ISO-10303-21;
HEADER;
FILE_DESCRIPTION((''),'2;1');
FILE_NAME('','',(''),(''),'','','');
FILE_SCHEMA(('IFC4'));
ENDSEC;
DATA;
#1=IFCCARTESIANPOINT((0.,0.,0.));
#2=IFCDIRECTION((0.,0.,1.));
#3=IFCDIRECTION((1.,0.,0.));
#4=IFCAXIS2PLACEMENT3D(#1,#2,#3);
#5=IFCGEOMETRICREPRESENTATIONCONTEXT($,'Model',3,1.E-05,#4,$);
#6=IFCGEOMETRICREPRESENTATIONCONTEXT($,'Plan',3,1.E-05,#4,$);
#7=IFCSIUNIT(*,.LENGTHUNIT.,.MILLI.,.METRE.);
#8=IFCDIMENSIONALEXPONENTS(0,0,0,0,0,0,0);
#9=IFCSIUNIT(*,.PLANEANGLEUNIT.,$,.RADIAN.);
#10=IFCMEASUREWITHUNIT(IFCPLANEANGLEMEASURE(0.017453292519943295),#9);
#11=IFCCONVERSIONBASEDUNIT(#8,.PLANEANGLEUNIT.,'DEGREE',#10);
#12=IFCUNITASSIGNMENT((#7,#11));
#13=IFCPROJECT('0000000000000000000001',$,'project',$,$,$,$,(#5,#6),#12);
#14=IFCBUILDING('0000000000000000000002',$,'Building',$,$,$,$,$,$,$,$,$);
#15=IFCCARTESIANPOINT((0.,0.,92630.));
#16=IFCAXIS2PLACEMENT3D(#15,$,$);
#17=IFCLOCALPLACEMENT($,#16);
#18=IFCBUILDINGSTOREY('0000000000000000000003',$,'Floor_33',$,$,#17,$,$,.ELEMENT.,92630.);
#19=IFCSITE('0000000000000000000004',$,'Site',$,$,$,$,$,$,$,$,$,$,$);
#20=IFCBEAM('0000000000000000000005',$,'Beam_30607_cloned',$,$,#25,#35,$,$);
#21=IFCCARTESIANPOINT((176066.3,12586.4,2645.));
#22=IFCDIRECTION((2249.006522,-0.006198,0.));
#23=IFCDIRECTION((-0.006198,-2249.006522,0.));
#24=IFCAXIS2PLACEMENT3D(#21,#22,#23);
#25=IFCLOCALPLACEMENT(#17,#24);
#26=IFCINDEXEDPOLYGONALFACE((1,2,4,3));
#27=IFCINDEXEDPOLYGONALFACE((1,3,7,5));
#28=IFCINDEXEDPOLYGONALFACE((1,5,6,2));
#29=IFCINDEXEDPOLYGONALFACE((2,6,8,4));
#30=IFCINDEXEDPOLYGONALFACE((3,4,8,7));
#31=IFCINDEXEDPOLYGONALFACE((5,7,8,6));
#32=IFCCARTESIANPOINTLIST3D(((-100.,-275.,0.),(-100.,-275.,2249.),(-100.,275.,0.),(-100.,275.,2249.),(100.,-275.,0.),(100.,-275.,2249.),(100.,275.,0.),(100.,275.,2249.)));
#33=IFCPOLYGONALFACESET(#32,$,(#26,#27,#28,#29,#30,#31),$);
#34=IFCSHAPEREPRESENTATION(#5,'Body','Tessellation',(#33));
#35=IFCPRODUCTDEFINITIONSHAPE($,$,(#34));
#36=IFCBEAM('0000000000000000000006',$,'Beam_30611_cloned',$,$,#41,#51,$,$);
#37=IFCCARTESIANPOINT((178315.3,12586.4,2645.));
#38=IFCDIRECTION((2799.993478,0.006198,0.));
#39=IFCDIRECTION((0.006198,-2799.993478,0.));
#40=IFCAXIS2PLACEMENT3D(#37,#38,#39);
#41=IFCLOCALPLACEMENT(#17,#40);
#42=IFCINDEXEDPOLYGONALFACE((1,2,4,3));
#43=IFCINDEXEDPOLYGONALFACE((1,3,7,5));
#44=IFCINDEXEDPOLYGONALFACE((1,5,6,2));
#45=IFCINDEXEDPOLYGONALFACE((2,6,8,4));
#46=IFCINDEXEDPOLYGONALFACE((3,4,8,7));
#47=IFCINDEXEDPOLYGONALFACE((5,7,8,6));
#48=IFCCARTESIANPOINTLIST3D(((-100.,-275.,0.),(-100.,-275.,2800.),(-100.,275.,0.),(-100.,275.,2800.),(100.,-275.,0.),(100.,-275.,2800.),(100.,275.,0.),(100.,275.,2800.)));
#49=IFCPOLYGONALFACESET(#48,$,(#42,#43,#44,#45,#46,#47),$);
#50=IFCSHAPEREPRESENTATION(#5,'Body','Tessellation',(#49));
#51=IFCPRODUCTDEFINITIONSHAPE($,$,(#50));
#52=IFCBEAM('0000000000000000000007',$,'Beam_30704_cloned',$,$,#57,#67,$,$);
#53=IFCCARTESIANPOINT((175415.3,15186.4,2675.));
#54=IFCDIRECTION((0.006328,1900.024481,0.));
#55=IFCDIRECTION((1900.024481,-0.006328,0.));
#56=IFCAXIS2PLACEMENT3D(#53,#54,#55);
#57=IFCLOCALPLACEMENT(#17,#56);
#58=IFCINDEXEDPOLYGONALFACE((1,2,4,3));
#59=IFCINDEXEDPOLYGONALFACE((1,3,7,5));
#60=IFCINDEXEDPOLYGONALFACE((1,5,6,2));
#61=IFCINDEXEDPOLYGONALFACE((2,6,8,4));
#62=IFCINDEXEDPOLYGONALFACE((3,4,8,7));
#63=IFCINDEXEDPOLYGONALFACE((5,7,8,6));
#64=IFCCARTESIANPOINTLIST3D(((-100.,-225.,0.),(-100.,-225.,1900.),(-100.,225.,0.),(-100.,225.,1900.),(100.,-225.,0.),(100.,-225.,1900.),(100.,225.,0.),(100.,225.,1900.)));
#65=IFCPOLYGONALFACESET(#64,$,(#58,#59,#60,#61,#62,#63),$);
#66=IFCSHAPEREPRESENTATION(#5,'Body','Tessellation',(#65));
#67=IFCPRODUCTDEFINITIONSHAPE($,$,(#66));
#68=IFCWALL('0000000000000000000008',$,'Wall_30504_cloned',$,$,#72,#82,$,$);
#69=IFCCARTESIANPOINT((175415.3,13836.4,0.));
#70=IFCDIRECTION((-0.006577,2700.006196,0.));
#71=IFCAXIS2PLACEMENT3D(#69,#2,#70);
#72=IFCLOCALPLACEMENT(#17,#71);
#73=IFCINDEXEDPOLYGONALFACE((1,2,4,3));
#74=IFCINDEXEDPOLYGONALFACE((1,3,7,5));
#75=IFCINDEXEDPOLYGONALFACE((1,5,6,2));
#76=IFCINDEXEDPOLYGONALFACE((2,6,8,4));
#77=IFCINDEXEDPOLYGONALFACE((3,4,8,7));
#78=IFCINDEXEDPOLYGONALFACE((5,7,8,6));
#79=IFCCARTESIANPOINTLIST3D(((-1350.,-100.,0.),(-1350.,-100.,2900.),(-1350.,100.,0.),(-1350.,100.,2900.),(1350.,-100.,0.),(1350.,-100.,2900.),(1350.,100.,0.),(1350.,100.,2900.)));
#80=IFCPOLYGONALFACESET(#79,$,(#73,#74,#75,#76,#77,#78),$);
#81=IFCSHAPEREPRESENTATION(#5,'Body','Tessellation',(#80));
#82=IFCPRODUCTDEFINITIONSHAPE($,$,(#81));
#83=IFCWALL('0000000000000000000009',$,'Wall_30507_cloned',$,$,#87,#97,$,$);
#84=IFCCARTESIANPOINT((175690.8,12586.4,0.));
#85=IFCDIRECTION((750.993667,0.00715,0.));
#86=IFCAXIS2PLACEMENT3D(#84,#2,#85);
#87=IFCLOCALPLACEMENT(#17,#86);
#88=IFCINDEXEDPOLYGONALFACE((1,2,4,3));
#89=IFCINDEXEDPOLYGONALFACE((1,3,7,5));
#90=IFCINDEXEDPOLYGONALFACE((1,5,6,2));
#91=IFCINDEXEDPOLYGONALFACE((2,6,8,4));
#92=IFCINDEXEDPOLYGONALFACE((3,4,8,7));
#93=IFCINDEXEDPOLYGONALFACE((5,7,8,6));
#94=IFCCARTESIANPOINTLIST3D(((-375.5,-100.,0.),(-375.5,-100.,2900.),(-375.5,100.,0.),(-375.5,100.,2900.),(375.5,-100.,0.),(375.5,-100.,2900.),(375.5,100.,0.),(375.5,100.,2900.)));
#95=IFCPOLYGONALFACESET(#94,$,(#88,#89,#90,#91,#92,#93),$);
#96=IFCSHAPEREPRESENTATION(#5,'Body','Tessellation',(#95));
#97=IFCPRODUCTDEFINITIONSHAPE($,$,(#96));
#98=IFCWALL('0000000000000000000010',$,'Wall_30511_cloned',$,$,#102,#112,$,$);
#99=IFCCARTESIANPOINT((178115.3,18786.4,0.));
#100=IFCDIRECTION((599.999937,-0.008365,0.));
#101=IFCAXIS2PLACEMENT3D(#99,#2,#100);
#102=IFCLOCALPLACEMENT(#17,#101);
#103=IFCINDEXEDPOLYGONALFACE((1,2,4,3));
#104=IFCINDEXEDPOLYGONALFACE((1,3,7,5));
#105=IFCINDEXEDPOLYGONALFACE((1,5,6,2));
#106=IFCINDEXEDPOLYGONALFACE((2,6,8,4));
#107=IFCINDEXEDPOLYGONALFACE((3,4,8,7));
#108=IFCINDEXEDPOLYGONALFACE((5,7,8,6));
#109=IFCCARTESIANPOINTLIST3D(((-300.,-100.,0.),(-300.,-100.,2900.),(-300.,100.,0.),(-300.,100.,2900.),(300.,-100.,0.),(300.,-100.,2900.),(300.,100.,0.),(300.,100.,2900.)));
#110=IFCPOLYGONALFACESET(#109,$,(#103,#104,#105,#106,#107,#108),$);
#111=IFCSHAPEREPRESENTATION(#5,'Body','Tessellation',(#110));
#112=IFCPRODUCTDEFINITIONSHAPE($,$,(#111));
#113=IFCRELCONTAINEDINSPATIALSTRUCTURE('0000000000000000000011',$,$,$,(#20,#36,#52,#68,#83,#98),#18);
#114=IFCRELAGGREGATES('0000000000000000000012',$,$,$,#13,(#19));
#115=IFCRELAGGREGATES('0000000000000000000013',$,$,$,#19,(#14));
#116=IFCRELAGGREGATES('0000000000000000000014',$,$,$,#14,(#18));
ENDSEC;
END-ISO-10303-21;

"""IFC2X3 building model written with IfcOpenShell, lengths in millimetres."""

from ifc_helpers import new_model, entity, si_unit, converted_unit, frame, origin_with_axes, origin_2d, place, context, project, spatial, rectangle, extrude, source, transform, mapped, element, save


model = new_model("IFC2X3")

# Units and contexts
model_context = context("Model", 3, precision=1e-05, world=origin_with_axes())
plan_context = context("Plan", 3, precision=1e-05, world=origin_with_axes())
ifc_project = project(units=[si_unit("LENGTHUNIT", "METRE", prefix="MILLI"), converted_unit("PLANEANGLEUNIT", "DEGREE", entity("IfcPlaneAngleMeasure", 0.017453292519943295), si_unit("PLANEANGLEUNIT", "RADIAN"), dimensions=[0, 0, 0, 0, 0, 0, 0])], contexts=[model_context, plan_context])

# Site, building, storey
site = spatial("IfcSite", under=ifc_project, Name="Site")
building = spatial("IfcBuilding", under=site, Name="Building")
storey_placement = place(None, frame((0.0, 0.0, 92630.0)))
storey = spatial("IfcBuildingStorey", under=building, at=storey_placement, Name="Floor_33", CompositionType="ELEMENT", Elevation=92630.0)

# Beams
shared_shape_1 = source(origin_with_axes(), model_context, "Body", "SweptSolid", [
    extrude(rectangle(XDim=200.0, YDim=550.0, at=origin_2d()), origin_with_axes(), (0.0, 0.0, 1.0), 2249.0),
])
beam_1_placement = place(storey_placement, frame((176066.3, 12586.4, 2645.0), z_axis=(2249.006522, -0.006198, 0.0), x_axis=(-0.006198, -2249.006522, 0.0)))
element("IfcBeam", 1, at=beam_1_placement, inside=storey, Name="Beam_30607_cloned", context=model_context, shape_type="MappedRepresentation", body=[
    mapped(shared_shape_1, transform((0.0, 0.0, 0.0), x_axis=(1.0, 0.0, 0.0), y_axis=(0.0, 1.0, 0.0), z_axis=(0.0, 0.0, 1.0), scale=1.0)),
])
shared_shape_2 = source(origin_with_axes(), model_context, "Body", "SweptSolid", [
    extrude(rectangle(XDim=200.0, YDim=550.0, at=origin_2d()), origin_with_axes(), (0.0, 0.0, 1.0), 2800.0),
])
beam_2_placement = place(storey_placement, frame((178315.3, 12586.4, 2645.0), z_axis=(2799.993478, 0.006198, 0.0), x_axis=(0.006198, -2799.993478, 0.0)))
element("IfcBeam", 2, at=beam_2_placement, inside=storey, Name="Beam_30611_cloned", context=model_context, shape_type="MappedRepresentation", body=[
    mapped(shared_shape_2, transform((0.0, 0.0, 0.0), x_axis=(1.0, 0.0, 0.0), y_axis=(0.0, 1.0, 0.0), z_axis=(0.0, 0.0, 1.0), scale=1.0)),
])
shared_shape_3 = source(origin_with_axes(), model_context, "Body", "SweptSolid", [
    extrude(rectangle(XDim=200.0, YDim=450.0, at=origin_2d()), origin_with_axes(), (0.0, 0.0, 1.0), 1900.0),
])
beam_3_placement = place(storey_placement, frame((175415.3, 15186.4, 2675.0), z_axis=(0.006328, 1900.024481, 0.0), x_axis=(1900.024481, -0.006328, 0.0)))
element("IfcBeam", 3, at=beam_3_placement, inside=storey, Name="Beam_30704_cloned", context=model_context, shape_type="MappedRepresentation", body=[
    mapped(shared_shape_3, transform((0.0, 0.0, 0.0), x_axis=(1.0, 0.0, 0.0), y_axis=(0.0, 1.0, 0.0), z_axis=(0.0, 0.0, 1.0), scale=1.0)),
])

# Walls
shared_shape_4 = source(origin_with_axes(), model_context, "Body", "SweptSolid", [
    extrude(rectangle(XDim=2700.0, YDim=200.0, at=origin_2d()), origin_with_axes(), (0.0, 0.0, 1.0), 2900.0),
])
wall_1_placement = place(storey_placement, frame((175415.3, 13836.4, 0.0), z_axis=(0.0, 0.0, 1.0), x_axis=(-0.006577, 2700.006196, 0.0)))
element("IfcWall", 4, at=wall_1_placement, inside=storey, Name="Wall_30504_cloned", context=model_context, shape_type="MappedRepresentation", body=[
    mapped(shared_shape_4, transform((0.0, 0.0, 0.0), x_axis=(1.0, 0.0, 0.0), y_axis=(0.0, 1.0, 0.0), z_axis=(0.0, 0.0, 1.0), scale=1.0)),
])
shared_shape_5 = source(origin_with_axes(), model_context, "Body", "SweptSolid", [
    extrude(rectangle(XDim=751.0, YDim=200.0, at=origin_2d()), origin_with_axes(), (0.0, 0.0, 1.0), 2900.0),
])
wall_2_placement = place(storey_placement, frame((175690.8, 12586.4, 0.0), z_axis=(0.0, 0.0, 1.0), x_axis=(750.993667, 0.00715, 0.0)))
element("IfcWall", 5, at=wall_2_placement, inside=storey, Name="Wall_30507_cloned", context=model_context, shape_type="MappedRepresentation", body=[
    mapped(shared_shape_5, transform((0.0, 0.0, 0.0), x_axis=(1.0, 0.0, 0.0), y_axis=(0.0, 1.0, 0.0), z_axis=(0.0, 0.0, 1.0), scale=1.0)),
])
shared_shape_6 = source(origin_with_axes(), model_context, "Body", "SweptSolid", [
    extrude(rectangle(XDim=600.0, YDim=200.0, at=origin_2d()), origin_with_axes(), (0.0, 0.0, 1.0), 2900.0),
])
wall_3_placement = place(storey_placement, frame((178115.3, 18786.4, 0.0), z_axis=(0.0, 0.0, 1.0), x_axis=(599.999937, -0.008365, 0.0)))
element("IfcWall", 6, at=wall_3_placement, inside=storey, Name="Wall_30511_cloned", context=model_context, shape_type="MappedRepresentation", body=[
    mapped(shared_shape_6, transform((0.0, 0.0, 0.0), x_axis=(1.0, 0.0, 0.0), y_axis=(0.0, 1.0, 0.0), z_axis=(0.0, 0.0, 1.0), scale=1.0)),
])

save(model, "model.ifc")
